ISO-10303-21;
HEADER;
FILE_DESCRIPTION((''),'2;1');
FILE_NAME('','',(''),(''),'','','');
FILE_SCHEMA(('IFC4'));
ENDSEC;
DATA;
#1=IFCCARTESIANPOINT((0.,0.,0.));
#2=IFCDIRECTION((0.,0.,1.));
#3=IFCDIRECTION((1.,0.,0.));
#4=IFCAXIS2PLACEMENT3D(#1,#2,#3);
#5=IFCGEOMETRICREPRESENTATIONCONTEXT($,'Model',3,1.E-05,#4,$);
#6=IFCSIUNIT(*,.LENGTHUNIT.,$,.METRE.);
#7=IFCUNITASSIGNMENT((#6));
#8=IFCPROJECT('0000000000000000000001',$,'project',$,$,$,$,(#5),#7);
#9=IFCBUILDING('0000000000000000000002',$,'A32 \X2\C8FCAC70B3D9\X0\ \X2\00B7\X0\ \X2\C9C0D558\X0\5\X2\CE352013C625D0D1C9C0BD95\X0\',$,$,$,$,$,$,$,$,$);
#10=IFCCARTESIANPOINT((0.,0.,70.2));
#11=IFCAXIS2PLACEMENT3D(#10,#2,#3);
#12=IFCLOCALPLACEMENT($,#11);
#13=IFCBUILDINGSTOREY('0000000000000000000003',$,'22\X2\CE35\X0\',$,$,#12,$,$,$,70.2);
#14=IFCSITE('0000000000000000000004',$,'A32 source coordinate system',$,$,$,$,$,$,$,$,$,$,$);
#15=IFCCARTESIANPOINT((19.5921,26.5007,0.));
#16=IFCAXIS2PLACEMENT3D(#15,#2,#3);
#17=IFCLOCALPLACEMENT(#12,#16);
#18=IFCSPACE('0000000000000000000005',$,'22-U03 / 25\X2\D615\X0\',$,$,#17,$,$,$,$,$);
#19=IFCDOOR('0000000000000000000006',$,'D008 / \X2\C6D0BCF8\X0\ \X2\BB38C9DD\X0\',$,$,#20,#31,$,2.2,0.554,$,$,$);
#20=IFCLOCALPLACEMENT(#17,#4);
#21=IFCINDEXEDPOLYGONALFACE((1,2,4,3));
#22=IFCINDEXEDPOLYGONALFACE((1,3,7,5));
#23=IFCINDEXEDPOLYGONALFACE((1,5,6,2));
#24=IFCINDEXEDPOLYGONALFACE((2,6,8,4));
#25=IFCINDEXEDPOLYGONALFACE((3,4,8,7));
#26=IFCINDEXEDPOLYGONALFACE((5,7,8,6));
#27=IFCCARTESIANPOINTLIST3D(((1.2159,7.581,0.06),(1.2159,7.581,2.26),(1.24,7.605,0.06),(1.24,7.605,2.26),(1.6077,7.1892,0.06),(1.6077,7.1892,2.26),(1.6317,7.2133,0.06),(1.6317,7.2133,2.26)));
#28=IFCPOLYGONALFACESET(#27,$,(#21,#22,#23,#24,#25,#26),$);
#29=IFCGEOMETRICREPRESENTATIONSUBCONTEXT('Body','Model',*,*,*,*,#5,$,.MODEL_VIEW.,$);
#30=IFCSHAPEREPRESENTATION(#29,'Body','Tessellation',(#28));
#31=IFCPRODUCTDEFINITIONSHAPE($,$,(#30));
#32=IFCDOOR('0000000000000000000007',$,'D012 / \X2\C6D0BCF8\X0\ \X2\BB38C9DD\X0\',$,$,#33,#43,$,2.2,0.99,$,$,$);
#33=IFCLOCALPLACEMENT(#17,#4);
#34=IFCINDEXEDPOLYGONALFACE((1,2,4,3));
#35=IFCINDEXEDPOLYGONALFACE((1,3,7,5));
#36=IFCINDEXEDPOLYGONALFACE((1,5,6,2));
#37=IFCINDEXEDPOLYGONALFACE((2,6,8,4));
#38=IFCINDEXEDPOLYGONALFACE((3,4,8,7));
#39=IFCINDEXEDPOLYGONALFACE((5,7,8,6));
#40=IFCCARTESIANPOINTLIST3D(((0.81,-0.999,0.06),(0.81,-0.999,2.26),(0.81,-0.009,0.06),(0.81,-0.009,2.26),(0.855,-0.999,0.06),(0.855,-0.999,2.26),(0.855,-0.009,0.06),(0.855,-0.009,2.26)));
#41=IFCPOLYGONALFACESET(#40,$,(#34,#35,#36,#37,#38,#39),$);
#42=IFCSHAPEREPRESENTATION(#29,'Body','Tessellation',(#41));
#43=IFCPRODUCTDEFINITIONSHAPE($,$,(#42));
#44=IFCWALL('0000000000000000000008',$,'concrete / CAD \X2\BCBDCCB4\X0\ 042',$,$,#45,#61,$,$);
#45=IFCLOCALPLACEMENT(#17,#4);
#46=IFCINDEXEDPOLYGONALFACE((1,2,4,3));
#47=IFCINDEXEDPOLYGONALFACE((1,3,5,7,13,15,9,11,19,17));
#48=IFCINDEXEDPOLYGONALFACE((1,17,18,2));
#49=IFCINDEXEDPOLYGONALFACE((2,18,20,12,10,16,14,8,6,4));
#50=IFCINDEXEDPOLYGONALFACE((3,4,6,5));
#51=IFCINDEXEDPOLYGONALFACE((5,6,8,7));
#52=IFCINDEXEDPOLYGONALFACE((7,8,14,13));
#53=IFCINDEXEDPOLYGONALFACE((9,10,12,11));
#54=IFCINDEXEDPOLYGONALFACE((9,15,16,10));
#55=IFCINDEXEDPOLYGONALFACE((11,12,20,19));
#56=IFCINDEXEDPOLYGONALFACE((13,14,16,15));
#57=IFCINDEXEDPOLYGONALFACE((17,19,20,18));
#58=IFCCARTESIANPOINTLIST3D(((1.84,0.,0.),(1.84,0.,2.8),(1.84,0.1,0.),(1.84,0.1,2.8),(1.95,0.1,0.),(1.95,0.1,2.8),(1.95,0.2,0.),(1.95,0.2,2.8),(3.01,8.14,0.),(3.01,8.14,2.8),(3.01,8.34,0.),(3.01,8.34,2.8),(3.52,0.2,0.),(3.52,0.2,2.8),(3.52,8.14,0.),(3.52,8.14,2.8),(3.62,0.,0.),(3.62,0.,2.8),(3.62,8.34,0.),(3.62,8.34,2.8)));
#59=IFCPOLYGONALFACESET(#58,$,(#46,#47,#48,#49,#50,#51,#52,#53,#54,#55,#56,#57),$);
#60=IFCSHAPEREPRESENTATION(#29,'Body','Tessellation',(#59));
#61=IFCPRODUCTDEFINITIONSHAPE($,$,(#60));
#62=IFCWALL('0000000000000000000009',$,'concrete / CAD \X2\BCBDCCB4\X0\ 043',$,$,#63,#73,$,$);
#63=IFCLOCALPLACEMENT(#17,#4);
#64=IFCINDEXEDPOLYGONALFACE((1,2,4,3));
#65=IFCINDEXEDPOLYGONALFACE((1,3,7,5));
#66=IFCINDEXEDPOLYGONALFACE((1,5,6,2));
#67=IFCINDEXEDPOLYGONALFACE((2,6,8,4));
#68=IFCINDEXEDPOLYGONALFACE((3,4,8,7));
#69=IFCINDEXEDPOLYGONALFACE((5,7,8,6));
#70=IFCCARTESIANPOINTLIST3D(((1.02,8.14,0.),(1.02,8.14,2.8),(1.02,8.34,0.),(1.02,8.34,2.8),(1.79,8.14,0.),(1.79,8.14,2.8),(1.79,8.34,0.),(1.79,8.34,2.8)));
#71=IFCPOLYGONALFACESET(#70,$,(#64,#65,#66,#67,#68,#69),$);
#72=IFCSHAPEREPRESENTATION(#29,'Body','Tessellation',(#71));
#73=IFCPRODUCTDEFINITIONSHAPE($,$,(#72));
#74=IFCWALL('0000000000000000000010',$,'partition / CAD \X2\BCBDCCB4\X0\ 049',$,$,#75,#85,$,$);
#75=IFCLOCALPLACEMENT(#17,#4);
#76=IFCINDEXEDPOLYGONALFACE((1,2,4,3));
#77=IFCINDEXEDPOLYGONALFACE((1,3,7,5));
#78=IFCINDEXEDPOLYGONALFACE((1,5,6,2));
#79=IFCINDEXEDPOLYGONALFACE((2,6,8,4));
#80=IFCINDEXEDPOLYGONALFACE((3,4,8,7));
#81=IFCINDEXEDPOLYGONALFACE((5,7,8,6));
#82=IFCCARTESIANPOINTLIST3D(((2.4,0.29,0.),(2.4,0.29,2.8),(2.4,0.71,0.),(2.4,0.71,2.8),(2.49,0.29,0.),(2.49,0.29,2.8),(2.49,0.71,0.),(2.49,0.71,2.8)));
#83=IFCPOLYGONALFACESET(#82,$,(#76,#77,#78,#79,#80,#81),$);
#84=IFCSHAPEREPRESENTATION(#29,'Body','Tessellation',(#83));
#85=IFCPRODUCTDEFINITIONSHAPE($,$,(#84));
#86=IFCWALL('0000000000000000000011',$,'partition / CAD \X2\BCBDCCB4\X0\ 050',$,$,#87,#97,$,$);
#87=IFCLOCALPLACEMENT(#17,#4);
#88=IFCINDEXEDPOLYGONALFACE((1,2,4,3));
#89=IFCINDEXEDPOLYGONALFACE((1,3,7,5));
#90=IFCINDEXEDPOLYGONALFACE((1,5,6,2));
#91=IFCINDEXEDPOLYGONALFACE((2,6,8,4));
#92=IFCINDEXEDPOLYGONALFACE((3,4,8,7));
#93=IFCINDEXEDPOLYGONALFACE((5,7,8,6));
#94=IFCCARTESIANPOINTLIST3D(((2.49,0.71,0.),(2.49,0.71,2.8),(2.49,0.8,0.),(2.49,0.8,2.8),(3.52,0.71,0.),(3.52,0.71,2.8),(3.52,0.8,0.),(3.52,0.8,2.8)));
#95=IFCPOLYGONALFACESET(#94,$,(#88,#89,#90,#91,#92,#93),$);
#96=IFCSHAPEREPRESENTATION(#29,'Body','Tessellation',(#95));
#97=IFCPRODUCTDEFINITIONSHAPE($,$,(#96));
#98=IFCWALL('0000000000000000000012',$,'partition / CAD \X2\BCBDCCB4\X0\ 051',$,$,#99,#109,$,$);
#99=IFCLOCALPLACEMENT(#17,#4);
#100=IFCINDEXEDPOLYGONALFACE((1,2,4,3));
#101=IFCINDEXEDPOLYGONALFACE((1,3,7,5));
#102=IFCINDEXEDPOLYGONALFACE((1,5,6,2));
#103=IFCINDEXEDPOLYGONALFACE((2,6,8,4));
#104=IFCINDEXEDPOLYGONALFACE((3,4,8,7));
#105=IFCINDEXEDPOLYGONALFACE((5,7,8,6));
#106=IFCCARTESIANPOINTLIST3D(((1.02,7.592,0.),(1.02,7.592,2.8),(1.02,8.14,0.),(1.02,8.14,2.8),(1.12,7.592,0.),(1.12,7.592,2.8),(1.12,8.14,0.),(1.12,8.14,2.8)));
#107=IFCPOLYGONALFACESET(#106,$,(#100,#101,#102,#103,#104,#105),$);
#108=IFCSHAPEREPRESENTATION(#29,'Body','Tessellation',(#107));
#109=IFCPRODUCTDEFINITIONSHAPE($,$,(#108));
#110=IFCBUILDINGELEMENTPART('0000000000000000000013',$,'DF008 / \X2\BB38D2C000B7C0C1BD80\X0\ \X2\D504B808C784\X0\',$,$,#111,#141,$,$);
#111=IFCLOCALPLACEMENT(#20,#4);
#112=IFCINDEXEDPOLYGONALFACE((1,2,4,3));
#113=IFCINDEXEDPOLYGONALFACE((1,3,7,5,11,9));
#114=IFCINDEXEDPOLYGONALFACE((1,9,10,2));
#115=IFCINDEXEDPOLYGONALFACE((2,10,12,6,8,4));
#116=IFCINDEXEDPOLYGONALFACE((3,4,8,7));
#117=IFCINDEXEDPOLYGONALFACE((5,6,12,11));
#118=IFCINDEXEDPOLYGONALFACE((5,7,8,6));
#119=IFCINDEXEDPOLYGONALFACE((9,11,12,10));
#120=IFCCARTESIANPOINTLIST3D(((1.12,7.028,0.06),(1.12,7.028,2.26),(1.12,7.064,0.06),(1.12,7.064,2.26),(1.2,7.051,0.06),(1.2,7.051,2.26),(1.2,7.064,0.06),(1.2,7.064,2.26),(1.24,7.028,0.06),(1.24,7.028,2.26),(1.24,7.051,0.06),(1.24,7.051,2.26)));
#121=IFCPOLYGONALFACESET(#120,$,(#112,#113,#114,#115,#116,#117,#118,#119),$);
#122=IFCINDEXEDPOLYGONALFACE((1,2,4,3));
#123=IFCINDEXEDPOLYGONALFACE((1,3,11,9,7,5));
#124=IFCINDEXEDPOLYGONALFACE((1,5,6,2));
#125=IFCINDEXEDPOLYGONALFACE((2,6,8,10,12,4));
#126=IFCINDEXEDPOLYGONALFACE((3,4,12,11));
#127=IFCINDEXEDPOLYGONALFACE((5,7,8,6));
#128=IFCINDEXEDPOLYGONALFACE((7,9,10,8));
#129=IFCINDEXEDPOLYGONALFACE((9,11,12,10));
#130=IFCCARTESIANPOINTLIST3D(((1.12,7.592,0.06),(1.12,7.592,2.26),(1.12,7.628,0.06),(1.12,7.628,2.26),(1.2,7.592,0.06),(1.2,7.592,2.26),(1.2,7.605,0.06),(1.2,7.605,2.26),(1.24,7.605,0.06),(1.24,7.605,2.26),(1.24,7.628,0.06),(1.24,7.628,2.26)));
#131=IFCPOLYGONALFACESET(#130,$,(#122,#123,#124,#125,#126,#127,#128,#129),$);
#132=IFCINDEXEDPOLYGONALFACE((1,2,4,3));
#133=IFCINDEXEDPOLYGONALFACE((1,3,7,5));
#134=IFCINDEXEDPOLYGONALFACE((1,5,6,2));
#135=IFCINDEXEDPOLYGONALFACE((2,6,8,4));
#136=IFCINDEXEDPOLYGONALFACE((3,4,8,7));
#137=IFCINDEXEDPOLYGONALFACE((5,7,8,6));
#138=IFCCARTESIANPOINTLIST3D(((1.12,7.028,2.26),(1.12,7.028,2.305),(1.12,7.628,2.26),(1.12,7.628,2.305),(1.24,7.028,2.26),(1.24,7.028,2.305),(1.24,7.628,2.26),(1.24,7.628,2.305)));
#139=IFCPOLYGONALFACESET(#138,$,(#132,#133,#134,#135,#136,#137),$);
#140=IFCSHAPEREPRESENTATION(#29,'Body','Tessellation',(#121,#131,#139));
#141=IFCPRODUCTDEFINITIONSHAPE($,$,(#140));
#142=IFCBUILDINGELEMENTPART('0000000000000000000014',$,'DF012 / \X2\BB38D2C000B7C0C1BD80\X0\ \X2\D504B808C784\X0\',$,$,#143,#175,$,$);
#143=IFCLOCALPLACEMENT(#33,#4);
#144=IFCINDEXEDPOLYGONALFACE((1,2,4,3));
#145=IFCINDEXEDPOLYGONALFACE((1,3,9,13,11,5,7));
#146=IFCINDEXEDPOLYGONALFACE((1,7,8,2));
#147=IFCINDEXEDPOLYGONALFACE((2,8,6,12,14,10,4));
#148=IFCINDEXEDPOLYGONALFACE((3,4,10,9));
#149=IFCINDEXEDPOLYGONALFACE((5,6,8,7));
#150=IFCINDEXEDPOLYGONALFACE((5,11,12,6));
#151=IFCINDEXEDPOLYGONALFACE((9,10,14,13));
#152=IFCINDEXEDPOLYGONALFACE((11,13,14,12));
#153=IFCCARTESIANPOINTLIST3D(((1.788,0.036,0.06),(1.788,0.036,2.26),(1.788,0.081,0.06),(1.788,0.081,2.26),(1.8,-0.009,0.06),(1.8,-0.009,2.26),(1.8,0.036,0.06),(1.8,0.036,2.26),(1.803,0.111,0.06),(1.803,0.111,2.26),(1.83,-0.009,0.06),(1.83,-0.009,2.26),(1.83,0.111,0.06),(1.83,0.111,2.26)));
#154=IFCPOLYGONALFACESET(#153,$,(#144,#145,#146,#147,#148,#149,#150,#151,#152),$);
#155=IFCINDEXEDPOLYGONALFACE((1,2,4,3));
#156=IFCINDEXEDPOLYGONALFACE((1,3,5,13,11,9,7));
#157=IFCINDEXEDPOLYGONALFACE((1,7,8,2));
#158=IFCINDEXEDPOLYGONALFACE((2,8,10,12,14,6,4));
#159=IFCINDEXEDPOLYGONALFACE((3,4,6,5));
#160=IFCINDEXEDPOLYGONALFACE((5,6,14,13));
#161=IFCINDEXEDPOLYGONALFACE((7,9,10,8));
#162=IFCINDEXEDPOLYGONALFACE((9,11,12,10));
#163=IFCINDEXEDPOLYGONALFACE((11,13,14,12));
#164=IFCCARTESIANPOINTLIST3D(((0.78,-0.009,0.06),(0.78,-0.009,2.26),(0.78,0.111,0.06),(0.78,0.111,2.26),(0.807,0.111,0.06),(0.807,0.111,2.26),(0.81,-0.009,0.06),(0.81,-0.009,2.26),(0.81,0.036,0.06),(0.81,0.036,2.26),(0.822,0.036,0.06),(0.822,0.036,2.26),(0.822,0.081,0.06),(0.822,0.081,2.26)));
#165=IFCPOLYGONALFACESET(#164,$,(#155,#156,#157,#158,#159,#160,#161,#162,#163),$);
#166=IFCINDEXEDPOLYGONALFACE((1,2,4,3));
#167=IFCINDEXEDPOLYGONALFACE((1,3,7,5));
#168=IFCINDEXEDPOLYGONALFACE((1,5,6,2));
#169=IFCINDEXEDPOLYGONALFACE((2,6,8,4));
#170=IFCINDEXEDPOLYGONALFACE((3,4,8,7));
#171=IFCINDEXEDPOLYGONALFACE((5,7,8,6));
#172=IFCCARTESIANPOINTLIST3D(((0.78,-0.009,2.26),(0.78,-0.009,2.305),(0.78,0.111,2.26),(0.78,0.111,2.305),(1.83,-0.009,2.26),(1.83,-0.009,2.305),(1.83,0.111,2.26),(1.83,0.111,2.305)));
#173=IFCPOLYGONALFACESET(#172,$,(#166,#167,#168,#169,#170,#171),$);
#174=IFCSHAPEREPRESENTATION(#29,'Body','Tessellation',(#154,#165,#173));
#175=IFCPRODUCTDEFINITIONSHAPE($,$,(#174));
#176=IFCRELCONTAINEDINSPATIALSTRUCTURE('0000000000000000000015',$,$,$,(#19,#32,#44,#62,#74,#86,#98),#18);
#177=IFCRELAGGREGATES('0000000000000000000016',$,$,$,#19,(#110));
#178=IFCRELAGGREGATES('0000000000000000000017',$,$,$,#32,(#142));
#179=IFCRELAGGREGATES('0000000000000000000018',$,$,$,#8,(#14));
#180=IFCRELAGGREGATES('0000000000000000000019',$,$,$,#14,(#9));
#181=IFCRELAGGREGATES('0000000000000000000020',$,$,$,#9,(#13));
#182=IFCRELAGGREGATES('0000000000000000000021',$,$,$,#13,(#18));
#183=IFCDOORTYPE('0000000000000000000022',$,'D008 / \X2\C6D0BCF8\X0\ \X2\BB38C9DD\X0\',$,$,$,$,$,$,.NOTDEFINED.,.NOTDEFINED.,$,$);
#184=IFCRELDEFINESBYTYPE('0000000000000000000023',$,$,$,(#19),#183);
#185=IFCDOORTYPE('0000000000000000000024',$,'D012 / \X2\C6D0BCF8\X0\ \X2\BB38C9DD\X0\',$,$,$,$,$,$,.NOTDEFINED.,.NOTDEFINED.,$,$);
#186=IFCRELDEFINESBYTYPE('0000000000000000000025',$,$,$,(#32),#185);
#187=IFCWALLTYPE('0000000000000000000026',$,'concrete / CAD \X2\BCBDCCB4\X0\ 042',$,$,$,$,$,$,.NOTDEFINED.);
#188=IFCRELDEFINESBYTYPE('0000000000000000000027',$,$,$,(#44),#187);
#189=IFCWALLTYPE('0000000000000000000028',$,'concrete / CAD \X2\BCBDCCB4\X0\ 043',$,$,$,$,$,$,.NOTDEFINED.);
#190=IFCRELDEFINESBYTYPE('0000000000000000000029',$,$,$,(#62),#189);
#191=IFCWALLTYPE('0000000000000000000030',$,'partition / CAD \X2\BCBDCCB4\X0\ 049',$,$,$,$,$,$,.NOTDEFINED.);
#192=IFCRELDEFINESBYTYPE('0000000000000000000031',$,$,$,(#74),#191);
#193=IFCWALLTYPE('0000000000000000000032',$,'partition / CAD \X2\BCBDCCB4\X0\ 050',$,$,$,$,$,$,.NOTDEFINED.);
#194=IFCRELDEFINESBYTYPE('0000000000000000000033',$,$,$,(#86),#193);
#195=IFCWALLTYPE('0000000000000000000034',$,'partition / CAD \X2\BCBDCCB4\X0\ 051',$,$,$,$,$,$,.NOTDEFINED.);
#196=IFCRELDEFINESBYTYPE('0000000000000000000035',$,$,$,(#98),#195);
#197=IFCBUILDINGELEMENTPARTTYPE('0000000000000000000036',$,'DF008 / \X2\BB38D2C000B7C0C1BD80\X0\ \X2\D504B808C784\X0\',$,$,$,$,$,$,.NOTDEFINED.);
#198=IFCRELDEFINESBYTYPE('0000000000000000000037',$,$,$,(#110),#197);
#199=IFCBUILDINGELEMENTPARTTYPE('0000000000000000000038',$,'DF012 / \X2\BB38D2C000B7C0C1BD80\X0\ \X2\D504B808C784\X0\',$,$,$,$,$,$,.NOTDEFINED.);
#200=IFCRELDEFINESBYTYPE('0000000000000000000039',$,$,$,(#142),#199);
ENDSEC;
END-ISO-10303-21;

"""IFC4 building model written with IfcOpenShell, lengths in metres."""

from ifc_helpers import new_model, si_unit, frame, origin, origin_with_axes, place, context, subcontext, project, spatial, polyline, outline, extrude, source, transform, mapped, type_object, type_shapes, element, aggregate, save


model = new_model("IFC4")

# Units and contexts
model_context = context("Model", 3, precision=1e-05, world=origin_with_axes())
body_context = subcontext(model_context, "Body", "Model", "MODEL_VIEW")
ifc_project = project(units=[si_unit("LENGTHUNIT", "METRE")], contexts=[model_context])

# Site, building, storey, space
storey_placement = place(None, frame((0.0, 0.0, 70.2), z_axis=(0.0, 0.0, 1.0), x_axis=(1.0, 0.0, 0.0)))
space_placement = place(storey_placement, frame((19.5921, 26.5007, 0.0), z_axis=(0.0, 0.0, 1.0), x_axis=(1.0, 0.0, 0.0)))
site = spatial("IfcSite", under=ifc_project, Name="A32 source coordinate system")
building = spatial("IfcBuilding", under=site, Name="A32 주거동 · 지하5층–옥탑지붕")
storey = spatial("IfcBuildingStorey", under=building, at=storey_placement, Name="22층", Elevation=70.2)
space = spatial("IfcSpace", under=storey, at=space_placement, Name="22-U03 / 25형")

# Doors
door_type_1 = type_object("IfcDoorType", Name="D008 / 원본 문짝", OperationType="NOTDEFINED", PredefinedType="NOTDEFINED")
shared_shape_1 = source(origin(), body_context, "Body", "SweptSolid", [
    extrude(outline(polyline([(1.24, 7.605), (1.6317, 7.2133), (1.6077, 7.1892), (1.2159, 7.581), (1.24, 7.605)])), frame((0.0, 0.0, 0.06)), (0.0, 0.0, 1.0), 2.2),
])
type_shapes(door_type_1, [shared_shape_1])
door_1_placement = place(space_placement, origin_with_axes())
door_1 = element("IfcDoor", 1, at=door_1_placement, inside=space, type_object=door_type_1, Name="D008 / 원본 문짝", OverallHeight=2.2, OverallWidth=0.554, context=body_context, shape_type="MappedRepresentation", body=[
    mapped(shared_shape_1, transform((0.0, 0.0, 0.0), scale=1.0)),
])
door_type_2 = type_object("IfcDoorType", Name="D012 / 원본 문짝", OperationType="NOTDEFINED", PredefinedType="NOTDEFINED")
shared_shape_2 = source(origin(), body_context, "Body", "SweptSolid", [
    extrude(outline(polyline([(0.855, -0.999), (0.81, -0.999), (0.81, -0.009), (0.855, -0.009), (0.855, -0.999)])), frame((0.0, 0.0, 0.06)), (0.0, 0.0, 1.0), 2.2),
])
type_shapes(door_type_2, [shared_shape_2])
door_2_placement = place(space_placement, origin_with_axes())
door_2 = element("IfcDoor", 2, at=door_2_placement, inside=space, type_object=door_type_2, Name="D012 / 원본 문짝", OverallHeight=2.2, OverallWidth=0.99, context=body_context, shape_type="MappedRepresentation", body=[
    mapped(shared_shape_2, transform((0.0, 0.0, 0.0), scale=1.0)),
])

# Walls
wall_type_1 = type_object("IfcWallType", Name="concrete / CAD 벽체 042", PredefinedType="NOTDEFINED")
shared_shape_3 = source(origin(), body_context, "Body", "SweptSolid", [
    extrude(outline(polyline([(3.01, 8.34), (3.97, 8.34), (3.97, 8.34), (3.62, 8.34), (3.62, 0.0), (1.84, 0.0), (1.84, 0.1), (1.95, 0.1), (1.95, 0.2), (3.52, 0.2), (3.52, 8.14), (3.01, 8.14), (3.01, 8.34)])), origin(), (0.0, 0.0, 1.0), 2.8),
])
type_shapes(wall_type_1, [shared_shape_3])
wall_1_placement = place(space_placement, origin_with_axes())
element("IfcWall", 3, at=wall_1_placement, inside=space, type_object=wall_type_1, Name="concrete / CAD 벽체 042", context=body_context, shape_type="MappedRepresentation", body=[
    mapped(shared_shape_3, transform((0.0, 0.0, 0.0), scale=1.0)),
])
wall_type_2 = type_object("IfcWallType", Name="concrete / CAD 벽체 043", PredefinedType="NOTDEFINED")
shared_shape_4 = source(origin(), body_context, "Body", "SweptSolid", [
    extrude(outline(polyline([(1.79, 8.14), (1.02, 8.14), (1.02, 8.34), (1.79, 8.34), (1.79, 8.14)])), origin(), (0.0, 0.0, 1.0), 2.8),
])
type_shapes(wall_type_2, [shared_shape_4])
wall_2_placement = place(space_placement, origin_with_axes())
element("IfcWall", 4, at=wall_2_placement, inside=space, type_object=wall_type_2, Name="concrete / CAD 벽체 043", context=body_context, shape_type="MappedRepresentation", body=[
    mapped(shared_shape_4, transform((0.0, 0.0, 0.0), scale=1.0)),
])
wall_type_3 = type_object("IfcWallType", Name="partition / CAD 벽체 049", PredefinedType="NOTDEFINED")
shared_shape_5 = source(origin(), body_context, "Body", "SweptSolid", [
    extrude(outline(polyline([(2.49, 0.29), (2.4, 0.29), (2.4, 0.71), (2.49, 0.71), (2.49, 0.29)])), origin(), (0.0, 0.0, 1.0), 2.8),
])
type_shapes(wall_type_3, [shared_shape_5])
wall_3_placement = place(space_placement, origin_with_axes())
element("IfcWall", 5, at=wall_3_placement, inside=space, type_object=wall_type_3, Name="partition / CAD 벽체 049", context=body_context, shape_type="MappedRepresentation", body=[
    mapped(shared_shape_5, transform((0.0, 0.0, 0.0), scale=1.0)),
])
wall_type_4 = type_object("IfcWallType", Name="partition / CAD 벽체 050", PredefinedType="NOTDEFINED")
shared_shape_6 = source(origin(), body_context, "Body", "SweptSolid", [
    extrude(outline(polyline([(2.49, 0.71), (2.49, 0.8), (3.52, 0.8), (3.52, 0.71), (2.49, 0.71)])), origin(), (0.0, 0.0, 1.0), 2.8),
])
type_shapes(wall_type_4, [shared_shape_6])
wall_4_placement = place(space_placement, origin_with_axes())
element("IfcWall", 6, at=wall_4_placement, inside=space, type_object=wall_type_4, Name="partition / CAD 벽체 050", context=body_context, shape_type="MappedRepresentation", body=[
    mapped(shared_shape_6, transform((0.0, 0.0, 0.0), scale=1.0)),
])
wall_type_5 = type_object("IfcWallType", Name="partition / CAD 벽체 051", PredefinedType="NOTDEFINED")
shared_shape_7 = source(origin(), body_context, "Body", "SweptSolid", [
    extrude(outline(polyline([(1.02, 8.14), (1.12, 8.14), (1.12, 7.592), (1.02, 7.592), (1.02, 8.14)])), origin(), (0.0, 0.0, 1.0), 2.8),
])
type_shapes(wall_type_5, [shared_shape_7])
wall_5_placement = place(space_placement, origin_with_axes())
element("IfcWall", 7, at=wall_5_placement, inside=space, type_object=wall_type_5, Name="partition / CAD 벽체 051", context=body_context, shape_type="MappedRepresentation", body=[
    mapped(shared_shape_7, transform((0.0, 0.0, 0.0), scale=1.0)),
])

# Building element parts
building_element_part_type_1 = type_object("IfcBuildingElementPartType", Name="DF008 / 문틀·상부 프레임", PredefinedType="NOTDEFINED")
shared_shape_8 = source(origin(), body_context, "Body", "SweptSolid", [
    extrude(outline(polyline([(1.12, 7.064), (1.2, 7.064), (1.2, 7.051), (1.24, 7.051), (1.24, 7.028), (1.12, 7.028), (1.12, 7.064)])), frame((0.0, 0.0, 0.06)), (0.0, 0.0, 1.0), 2.2),
    extrude(outline(polyline([(1.24, 7.628), (1.24, 7.605), (1.2, 7.605), (1.2, 7.592), (1.12, 7.592), (1.12, 7.628), (1.24, 7.628)])), frame((0.0, 0.0, 0.06)), (0.0, 0.0, 1.0), 2.2),
    extrude(outline(polyline([(1.12, 7.028), (1.12, 7.628), (1.24, 7.628), (1.24, 7.028), (1.12, 7.028)])), frame((0.0, 0.0, 2.26)), (0.0, 0.0, 1.0), 0.045),
])
type_shapes(building_element_part_type_1, [shared_shape_8])
building_element_part_1_placement = place(door_1_placement, origin_with_axes())
building_element_part_1 = element("IfcBuildingElementPart", 8, at=building_element_part_1_placement, type_object=building_element_part_type_1, Name="DF008 / 문틀·상부 프레임", context=body_context, shape_type="MappedRepresentation", body=[
    mapped(shared_shape_8, transform((0.0, 0.0, 0.0), scale=1.0)),
])
aggregate(door_1, [building_element_part_1])
building_element_part_type_2 = type_object("IfcBuildingElementPartType", Name="DF012 / 문틀·상부 프레임", PredefinedType="NOTDEFINED")
shared_shape_9 = source(origin(), body_context, "Body", "SweptSolid", [
    extrude(outline(polyline([(1.8, -0.009), (1.8, 0.036), (1.788, 0.036), (1.788, 0.081), (1.803, 0.111), (1.83, 0.111), (1.83, -0.009), (1.8, -0.009)])), frame((0.0, 0.0, 0.06)), (0.0, 0.0, 1.0), 2.2),
    extrude(outline(polyline([(0.78, 0.111), (0.807, 0.111), (0.822, 0.081), (0.822, 0.036), (0.81, 0.036), (0.81, -0.009), (0.78, -0.009), (0.78, 0.111)])), frame((0.0, 0.0, 0.06)), (0.0, 0.0, 1.0), 2.2),
    extrude(outline(polyline([(0.78, -0.009), (0.78, 0.111), (1.83, 0.111), (1.83, -0.009), (0.78, -0.009)])), frame((0.0, 0.0, 2.26)), (0.0, 0.0, 1.0), 0.045),
])
type_shapes(building_element_part_type_2, [shared_shape_9])
building_element_part_2_placement = place(door_2_placement, origin_with_axes())
building_element_part_2 = element("IfcBuildingElementPart", 9, at=building_element_part_2_placement, type_object=building_element_part_type_2, Name="DF012 / 문틀·상부 프레임", context=body_context, shape_type="MappedRepresentation", body=[
    mapped(shared_shape_9, transform((0.0, 0.0, 0.0), scale=1.0)),
])
aggregate(door_2, [building_element_part_2])

save(model, "model.ifc")
